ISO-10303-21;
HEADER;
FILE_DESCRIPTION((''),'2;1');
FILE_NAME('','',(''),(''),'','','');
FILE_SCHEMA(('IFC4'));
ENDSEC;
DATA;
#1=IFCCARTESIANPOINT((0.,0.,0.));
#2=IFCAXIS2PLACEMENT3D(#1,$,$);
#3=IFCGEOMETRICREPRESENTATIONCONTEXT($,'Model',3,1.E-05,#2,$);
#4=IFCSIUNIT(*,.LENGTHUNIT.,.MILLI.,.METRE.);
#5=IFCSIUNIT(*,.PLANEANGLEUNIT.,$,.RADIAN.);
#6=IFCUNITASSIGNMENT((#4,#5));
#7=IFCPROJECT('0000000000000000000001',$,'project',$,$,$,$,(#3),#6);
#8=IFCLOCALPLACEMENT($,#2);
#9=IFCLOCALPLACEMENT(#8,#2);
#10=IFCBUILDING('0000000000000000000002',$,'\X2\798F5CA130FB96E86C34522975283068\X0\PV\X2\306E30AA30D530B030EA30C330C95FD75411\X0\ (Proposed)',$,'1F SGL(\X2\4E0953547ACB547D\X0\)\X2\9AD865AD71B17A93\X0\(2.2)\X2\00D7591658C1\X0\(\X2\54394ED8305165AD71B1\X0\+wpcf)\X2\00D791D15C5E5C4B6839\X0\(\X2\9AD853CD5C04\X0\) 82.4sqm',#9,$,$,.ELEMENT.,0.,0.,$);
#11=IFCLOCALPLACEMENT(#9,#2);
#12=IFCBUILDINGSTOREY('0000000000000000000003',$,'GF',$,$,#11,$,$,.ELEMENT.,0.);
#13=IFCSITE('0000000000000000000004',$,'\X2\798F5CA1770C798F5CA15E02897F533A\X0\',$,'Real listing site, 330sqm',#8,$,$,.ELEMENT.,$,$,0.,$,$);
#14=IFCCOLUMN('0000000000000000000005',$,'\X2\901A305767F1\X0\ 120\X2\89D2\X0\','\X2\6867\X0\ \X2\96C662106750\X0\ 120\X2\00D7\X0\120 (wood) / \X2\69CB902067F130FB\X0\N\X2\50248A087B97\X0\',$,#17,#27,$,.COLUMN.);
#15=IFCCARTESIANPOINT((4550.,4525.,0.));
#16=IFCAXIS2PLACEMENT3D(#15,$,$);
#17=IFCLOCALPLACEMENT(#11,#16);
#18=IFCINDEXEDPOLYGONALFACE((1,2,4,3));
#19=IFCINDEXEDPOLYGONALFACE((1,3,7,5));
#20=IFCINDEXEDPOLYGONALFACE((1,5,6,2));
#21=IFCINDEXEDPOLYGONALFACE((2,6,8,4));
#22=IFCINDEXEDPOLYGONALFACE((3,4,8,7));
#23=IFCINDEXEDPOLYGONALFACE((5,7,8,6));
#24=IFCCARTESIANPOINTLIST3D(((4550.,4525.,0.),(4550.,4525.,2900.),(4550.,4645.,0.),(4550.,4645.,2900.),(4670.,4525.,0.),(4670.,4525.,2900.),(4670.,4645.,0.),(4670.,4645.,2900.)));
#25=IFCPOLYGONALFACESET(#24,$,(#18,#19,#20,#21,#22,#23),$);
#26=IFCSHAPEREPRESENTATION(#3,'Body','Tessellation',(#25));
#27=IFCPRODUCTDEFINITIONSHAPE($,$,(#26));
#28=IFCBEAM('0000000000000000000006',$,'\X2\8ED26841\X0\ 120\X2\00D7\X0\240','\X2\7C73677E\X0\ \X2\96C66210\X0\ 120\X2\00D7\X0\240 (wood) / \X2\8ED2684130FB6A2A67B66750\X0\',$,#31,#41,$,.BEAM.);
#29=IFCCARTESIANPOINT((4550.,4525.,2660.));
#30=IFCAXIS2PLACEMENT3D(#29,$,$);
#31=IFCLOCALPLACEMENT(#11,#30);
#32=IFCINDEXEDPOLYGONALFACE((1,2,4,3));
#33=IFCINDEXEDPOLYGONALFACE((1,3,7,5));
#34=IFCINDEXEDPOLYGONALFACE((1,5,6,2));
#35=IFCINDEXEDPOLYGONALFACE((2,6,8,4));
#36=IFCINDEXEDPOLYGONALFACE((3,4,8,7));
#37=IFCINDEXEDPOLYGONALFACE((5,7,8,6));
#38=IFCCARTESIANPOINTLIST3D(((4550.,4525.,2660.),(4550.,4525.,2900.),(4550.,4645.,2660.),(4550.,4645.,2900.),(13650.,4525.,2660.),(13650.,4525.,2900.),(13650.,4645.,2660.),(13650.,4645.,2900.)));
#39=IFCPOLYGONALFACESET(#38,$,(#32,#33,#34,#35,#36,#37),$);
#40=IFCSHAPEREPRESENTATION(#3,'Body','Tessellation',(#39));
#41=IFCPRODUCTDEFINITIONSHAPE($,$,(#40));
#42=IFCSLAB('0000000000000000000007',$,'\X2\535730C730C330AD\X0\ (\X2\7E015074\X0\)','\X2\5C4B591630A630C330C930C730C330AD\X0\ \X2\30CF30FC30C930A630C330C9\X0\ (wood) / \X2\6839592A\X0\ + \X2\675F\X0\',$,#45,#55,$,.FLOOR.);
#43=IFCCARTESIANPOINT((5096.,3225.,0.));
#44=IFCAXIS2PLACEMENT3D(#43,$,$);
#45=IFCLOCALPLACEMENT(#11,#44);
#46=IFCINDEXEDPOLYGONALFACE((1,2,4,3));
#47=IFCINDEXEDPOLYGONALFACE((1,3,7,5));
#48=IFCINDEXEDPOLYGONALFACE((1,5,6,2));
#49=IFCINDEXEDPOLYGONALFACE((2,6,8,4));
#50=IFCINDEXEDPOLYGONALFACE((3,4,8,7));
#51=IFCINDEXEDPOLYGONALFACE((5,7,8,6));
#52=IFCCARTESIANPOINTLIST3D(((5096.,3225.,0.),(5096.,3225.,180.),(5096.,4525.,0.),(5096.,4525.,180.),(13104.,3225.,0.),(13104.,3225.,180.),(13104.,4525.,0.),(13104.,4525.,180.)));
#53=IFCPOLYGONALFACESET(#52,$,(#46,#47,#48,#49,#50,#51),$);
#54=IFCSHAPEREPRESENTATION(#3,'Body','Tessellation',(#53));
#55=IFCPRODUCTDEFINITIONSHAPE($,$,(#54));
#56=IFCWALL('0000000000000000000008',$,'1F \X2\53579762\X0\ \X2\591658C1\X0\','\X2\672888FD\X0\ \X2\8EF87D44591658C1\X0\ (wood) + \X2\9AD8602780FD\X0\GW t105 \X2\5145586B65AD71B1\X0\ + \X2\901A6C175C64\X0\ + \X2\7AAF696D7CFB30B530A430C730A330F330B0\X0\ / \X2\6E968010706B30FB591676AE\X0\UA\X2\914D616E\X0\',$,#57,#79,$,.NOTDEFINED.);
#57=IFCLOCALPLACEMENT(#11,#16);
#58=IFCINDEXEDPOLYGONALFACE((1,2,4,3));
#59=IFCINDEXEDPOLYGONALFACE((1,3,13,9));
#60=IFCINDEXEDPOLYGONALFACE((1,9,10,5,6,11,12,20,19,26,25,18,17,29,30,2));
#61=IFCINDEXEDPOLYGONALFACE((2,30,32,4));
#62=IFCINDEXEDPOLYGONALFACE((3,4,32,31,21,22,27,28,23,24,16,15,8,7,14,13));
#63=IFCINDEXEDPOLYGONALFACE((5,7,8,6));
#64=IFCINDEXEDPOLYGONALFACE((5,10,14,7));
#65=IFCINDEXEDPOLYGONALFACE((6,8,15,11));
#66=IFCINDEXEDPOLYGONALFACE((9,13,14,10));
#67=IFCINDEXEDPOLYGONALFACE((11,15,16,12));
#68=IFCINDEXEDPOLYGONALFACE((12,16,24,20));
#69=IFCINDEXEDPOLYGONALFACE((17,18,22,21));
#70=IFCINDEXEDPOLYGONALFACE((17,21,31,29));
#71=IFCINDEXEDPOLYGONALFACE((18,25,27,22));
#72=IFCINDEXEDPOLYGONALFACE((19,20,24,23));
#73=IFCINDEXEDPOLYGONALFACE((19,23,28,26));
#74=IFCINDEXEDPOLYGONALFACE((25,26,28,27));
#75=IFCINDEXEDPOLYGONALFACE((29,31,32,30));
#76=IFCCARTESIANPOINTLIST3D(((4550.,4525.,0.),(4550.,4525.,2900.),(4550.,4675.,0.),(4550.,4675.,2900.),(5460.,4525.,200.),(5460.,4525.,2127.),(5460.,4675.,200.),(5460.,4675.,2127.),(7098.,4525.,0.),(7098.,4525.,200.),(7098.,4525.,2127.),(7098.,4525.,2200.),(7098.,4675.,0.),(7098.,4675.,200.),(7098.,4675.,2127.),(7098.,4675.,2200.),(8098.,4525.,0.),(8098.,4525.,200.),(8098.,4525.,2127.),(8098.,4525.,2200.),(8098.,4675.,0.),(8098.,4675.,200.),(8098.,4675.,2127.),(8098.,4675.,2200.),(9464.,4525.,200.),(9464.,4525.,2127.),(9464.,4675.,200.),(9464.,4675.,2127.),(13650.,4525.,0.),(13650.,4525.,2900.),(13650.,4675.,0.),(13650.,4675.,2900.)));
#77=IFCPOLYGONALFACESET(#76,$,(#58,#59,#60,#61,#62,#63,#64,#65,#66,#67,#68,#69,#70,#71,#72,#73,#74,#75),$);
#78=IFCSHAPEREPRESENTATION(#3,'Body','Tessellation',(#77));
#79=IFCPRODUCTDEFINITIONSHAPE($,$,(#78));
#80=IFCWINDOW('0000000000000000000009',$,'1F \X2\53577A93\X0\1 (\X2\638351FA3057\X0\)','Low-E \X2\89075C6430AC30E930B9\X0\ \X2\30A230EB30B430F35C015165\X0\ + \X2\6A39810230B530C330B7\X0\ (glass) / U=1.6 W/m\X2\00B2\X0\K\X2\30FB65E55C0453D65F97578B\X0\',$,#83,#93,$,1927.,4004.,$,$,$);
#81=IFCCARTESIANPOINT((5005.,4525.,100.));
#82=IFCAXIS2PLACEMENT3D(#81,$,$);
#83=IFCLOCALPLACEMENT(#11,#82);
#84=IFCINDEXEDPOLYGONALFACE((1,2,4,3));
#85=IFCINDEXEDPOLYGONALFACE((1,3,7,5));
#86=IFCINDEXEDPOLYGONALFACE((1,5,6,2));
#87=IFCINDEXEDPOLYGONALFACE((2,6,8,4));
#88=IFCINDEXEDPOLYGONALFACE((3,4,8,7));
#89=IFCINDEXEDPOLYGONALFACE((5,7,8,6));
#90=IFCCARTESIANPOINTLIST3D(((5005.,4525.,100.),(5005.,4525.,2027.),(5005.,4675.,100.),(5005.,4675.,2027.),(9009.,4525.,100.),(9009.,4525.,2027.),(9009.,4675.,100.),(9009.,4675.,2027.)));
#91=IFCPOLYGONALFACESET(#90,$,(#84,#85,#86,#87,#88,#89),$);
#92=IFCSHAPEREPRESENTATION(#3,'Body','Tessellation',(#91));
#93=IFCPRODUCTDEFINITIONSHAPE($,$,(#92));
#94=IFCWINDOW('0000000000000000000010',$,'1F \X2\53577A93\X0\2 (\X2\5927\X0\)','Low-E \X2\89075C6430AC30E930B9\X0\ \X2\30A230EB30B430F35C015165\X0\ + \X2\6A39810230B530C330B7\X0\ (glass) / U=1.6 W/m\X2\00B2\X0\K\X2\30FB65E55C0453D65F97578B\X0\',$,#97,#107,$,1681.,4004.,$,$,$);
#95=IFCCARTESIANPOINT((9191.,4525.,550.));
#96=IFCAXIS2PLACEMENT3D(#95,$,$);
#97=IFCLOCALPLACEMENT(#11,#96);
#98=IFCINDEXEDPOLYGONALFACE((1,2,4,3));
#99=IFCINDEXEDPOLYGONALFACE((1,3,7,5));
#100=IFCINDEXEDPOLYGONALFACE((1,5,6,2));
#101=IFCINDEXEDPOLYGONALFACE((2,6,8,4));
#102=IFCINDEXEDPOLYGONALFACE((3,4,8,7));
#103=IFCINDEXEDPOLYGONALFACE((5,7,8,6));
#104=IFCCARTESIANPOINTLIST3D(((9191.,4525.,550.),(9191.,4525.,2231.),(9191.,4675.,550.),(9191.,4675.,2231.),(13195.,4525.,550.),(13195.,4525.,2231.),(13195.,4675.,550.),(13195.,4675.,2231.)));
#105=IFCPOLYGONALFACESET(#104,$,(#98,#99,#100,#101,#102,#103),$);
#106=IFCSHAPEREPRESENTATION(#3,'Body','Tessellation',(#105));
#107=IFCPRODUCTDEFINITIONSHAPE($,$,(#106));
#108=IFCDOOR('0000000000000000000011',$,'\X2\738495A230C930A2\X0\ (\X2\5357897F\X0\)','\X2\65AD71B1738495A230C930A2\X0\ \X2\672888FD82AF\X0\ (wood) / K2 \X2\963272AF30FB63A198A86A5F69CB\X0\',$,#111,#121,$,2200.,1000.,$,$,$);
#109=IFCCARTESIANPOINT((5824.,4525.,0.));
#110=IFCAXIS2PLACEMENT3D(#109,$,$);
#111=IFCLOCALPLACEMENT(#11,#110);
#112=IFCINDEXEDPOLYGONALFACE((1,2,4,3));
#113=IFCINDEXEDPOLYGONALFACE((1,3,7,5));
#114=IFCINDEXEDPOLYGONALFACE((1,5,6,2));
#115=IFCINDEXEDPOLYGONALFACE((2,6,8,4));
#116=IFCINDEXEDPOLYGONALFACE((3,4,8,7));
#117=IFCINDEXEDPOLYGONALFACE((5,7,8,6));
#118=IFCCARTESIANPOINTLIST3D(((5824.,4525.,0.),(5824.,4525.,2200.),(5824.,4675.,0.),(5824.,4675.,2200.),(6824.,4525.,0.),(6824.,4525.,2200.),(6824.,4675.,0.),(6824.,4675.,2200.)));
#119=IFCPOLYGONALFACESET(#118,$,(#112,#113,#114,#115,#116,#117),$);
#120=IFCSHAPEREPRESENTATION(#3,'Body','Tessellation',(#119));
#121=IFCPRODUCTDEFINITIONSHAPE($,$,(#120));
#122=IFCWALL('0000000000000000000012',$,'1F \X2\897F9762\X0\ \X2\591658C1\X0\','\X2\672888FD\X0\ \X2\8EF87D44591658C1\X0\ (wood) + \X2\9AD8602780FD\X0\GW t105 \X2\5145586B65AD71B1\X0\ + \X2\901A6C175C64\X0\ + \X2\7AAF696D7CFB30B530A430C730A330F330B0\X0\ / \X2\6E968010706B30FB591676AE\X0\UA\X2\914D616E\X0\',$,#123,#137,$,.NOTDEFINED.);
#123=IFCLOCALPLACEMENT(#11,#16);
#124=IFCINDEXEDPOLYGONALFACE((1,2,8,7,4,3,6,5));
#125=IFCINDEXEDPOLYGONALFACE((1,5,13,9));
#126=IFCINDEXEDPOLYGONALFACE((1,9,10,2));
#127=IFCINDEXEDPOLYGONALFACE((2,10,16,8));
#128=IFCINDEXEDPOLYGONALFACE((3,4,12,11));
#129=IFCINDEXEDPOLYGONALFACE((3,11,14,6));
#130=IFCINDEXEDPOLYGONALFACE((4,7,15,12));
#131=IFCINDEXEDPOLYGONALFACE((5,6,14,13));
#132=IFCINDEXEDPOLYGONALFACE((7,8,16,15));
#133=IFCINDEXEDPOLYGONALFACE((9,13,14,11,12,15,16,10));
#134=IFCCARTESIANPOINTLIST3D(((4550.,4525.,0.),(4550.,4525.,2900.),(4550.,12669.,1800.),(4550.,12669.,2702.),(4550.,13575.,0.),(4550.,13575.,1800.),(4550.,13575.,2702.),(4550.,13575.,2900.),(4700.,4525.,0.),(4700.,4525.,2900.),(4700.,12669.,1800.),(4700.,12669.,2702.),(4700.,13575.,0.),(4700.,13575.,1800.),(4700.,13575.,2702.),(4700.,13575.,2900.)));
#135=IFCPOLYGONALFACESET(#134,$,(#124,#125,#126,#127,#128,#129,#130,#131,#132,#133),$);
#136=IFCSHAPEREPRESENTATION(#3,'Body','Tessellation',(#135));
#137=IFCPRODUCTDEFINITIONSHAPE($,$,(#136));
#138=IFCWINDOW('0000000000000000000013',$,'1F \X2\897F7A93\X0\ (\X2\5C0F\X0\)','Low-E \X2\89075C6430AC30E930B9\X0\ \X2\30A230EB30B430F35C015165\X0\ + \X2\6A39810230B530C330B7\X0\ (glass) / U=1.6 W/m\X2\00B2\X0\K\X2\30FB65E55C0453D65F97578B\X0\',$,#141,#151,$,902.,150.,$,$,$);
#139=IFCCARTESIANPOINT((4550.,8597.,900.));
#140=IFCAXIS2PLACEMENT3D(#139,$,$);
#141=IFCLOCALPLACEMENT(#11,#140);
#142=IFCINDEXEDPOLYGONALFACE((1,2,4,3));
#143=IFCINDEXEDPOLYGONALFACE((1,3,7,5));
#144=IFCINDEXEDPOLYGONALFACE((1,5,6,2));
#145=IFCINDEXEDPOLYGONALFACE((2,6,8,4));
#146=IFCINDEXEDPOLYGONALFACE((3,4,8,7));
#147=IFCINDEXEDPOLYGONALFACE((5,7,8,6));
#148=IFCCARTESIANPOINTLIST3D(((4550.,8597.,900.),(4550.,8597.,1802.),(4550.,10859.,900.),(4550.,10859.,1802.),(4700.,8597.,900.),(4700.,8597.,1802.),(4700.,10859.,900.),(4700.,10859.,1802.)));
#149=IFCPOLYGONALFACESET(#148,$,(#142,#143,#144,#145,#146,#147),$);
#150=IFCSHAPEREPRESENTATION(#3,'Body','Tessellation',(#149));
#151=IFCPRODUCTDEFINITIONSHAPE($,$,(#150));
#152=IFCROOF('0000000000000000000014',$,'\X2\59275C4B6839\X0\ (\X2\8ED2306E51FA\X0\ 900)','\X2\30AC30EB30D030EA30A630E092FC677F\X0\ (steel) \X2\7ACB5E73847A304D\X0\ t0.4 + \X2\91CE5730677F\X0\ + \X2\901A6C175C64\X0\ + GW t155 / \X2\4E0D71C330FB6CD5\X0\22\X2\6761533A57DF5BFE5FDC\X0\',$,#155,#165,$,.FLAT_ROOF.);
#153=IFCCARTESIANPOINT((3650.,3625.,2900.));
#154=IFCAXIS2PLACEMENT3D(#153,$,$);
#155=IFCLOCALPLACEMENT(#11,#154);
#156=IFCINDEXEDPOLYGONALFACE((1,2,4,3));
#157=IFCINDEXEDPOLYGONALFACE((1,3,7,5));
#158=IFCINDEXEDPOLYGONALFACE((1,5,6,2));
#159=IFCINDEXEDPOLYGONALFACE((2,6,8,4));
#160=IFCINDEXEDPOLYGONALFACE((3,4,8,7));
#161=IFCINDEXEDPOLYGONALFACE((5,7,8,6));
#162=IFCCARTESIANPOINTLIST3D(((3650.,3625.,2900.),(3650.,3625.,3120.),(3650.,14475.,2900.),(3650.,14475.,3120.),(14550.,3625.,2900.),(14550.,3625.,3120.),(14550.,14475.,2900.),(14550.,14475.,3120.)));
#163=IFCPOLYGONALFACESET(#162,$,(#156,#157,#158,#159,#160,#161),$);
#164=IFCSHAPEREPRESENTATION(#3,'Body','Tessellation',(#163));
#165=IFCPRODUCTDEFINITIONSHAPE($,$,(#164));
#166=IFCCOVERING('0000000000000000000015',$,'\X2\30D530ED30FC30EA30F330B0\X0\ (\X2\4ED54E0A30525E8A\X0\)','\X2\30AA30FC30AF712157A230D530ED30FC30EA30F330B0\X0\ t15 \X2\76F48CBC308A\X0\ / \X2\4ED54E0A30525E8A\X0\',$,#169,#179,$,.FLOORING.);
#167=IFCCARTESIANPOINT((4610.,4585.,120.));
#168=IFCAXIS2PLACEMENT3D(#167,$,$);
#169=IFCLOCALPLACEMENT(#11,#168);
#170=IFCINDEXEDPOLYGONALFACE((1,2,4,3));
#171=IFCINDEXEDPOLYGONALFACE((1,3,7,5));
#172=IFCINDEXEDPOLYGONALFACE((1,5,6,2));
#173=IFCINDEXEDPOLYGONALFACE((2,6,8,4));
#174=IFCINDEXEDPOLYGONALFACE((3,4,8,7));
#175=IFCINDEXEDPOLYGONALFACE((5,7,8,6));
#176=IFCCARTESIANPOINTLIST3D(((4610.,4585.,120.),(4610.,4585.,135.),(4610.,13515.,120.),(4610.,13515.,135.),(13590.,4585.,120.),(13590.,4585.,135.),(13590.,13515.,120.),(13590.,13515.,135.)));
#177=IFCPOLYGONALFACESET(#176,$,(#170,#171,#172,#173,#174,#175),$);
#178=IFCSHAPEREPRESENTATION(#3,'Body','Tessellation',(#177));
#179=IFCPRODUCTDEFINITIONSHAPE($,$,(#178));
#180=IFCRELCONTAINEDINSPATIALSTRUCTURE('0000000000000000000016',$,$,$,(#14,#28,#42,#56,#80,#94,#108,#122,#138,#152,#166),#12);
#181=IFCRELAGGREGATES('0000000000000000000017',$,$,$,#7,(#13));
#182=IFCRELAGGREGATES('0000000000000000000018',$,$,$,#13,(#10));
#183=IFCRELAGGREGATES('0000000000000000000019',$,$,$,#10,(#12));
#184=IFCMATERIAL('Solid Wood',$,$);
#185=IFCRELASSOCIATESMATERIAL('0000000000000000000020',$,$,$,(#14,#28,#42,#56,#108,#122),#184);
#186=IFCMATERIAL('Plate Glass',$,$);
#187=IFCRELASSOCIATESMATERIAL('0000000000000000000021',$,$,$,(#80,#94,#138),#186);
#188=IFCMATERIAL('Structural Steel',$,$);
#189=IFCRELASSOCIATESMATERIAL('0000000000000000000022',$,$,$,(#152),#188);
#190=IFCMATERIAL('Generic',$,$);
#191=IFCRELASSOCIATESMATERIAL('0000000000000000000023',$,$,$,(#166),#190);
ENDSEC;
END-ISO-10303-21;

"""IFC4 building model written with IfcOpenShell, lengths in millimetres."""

from ifc_helpers import new_model, si_unit, frame, frame_2d, origin, place, context, project, spatial, rectangle, extrude, material, element, fill, save


model = new_model("IFC4")

# Units and contexts
model_context = context("Model", 3, precision=1e-05, world=origin())
ifc_project = project(units=[si_unit("LENGTHUNIT", "METRE", prefix="MILLI"), si_unit("PLANEANGLEUNIT", "RADIAN")], contexts=[model_context])

# Site, building, storey
site_placement = place(None, origin())
site = spatial("IfcSite", under=ifc_project, at=site_placement, Name="福岡県福岡市西区", ObjectType="Real listing site, 330sqm", CompositionType="ELEMENT", RefElevation=0.0)
building_placement = place(site_placement, origin())
building = spatial("IfcBuilding", under=site, at=building_placement, Name="福岡・雨水利用とPVのオフグリッド志向 (Proposed)", ObjectType="1F SGL(三協立命)高断熱窓(2.2)×外壁(吹付け断熱+wpcf)×金属屋根(高反射) 82.4sqm", CompositionType="ELEMENT", ElevationOfRefHeight=0.0, ElevationOfTerrain=0.0)
storey_placement = place(building_placement, origin())
storey = spatial("IfcBuildingStorey", under=building, at=storey_placement, Name="GF", CompositionType="ELEMENT", Elevation=0.0)

# Column
ifc_material_1 = material(Name="Solid Wood")
column_placement = place(storey_placement, frame((4550.0, 4525.0, 0.0)))
element("IfcColumn", 1, at=column_placement, inside=storey, material=ifc_material_1, Name="通し柱 120角", Description="桧 集成材 120×120 (wood) / 構造柱・N値計算", PredefinedType="COLUMN", context=model_context, shape_type="SweptSolid", body=[
    extrude(rectangle(XDim=120.0, YDim=120.0, at=frame_2d((60.0, 60.0))), frame((4550.0, 4525.0, 0.0)), (0.0, 0.0, 1.0), 2900.0),
])

# Beam
beam_1_placement = place(storey_placement, frame((4550.0, 4525.0, 2660.0)))
element("IfcBeam", 2, at=beam_1_placement, inside=storey, material=ifc_material_1, Name="軒桁 120×240", Description="米松 集成 120×240 (wood) / 軒桁・横架材", PredefinedType="BEAM", context=model_context, shape_type="SweptSolid", body=[
    extrude(rectangle(XDim=9100.0, YDim=120.0, at=frame_2d((4550.0, 60.0))), frame((4550.0, 4525.0, 2660.0)), (0.0, 0.0, 1.0), 240.0),
])

# Slab
slab_1_placement = place(storey_placement, frame((5096.0, 3225.0, 0.0)))
element("IfcSlab", 3, at=slab_1_placement, inside=storey, material=ifc_material_1, Name="南デッキ (縁側)", Description="屋外ウッドデッキ ハードウッド (wood) / 根太 + 束", PredefinedType="FLOOR", context=model_context, shape_type="SweptSolid", body=[
    extrude(rectangle(XDim=8008.0, YDim=1300.0, at=frame_2d((4004.0, 650.0))), frame((5096.0, 3225.0, 0.0)), (0.0, 0.0, 1.0), 180.0),
])

# Wall, openings, windows, door
wall_1_placement = place(storey_placement, frame((4550.0, 4525.0, 0.0)))
wall_1 = element("IfcWall", 4, at=wall_1_placement, inside=storey, material=ifc_material_1, Name="1F 南面 外壁", Description="木製 軸組外壁 (wood) + 高性能GW t105 充填断熱 + 通気層 + 窯業系サイディング / 準耐火・外皮UA配慮", PredefinedType="NOTDEFINED", context=model_context, shape_type="SweptSolid", body=[
    extrude(rectangle(XDim=9100.0, YDim=150.0, at=frame_2d((4550.0, 75.0))), frame((4550.0, 4525.0, 0.0)), (0.0, 0.0, 1.0), 2900.0),
])
opening_1_placement = place(storey_placement, frame((5005.0, 4525.0, 100.0)))
opening_1 = element("IfcOpeningElement", 5, at=opening_1_placement, cuts=wall_1, PredefinedType="NOTDEFINED", context=model_context, shape_type="SweptSolid", body=[
    extrude(rectangle(XDim=4004.0, YDim=150.0, at=frame_2d((2002.0, 75.0))), frame((5005.0, 4525.0, 100.0)), (0.0, 0.0, 1.0), 1927.0),
])
opening_2_placement = place(storey_placement, frame((9191.0, 4525.0, 550.0)))
opening_2 = element("IfcOpeningElement", 6, at=opening_2_placement, cuts=wall_1, PredefinedType="NOTDEFINED", context=model_context, shape_type="SweptSolid", body=[
    extrude(rectangle(XDim=4004.0, YDim=150.0, at=frame_2d((2002.0, 75.0))), frame((9191.0, 4525.0, 550.0)), (0.0, 0.0, 1.0), 1681.0),
])
opening_3_placement = place(storey_placement, frame((5824.0, 4525.0, 0.0)))
opening_3 = element("IfcOpeningElement", 7, at=opening_3_placement, cuts=wall_1, PredefinedType="NOTDEFINED", context=model_context, shape_type="SweptSolid", body=[
    extrude(rectangle(XDim=1000.0, YDim=150.0, at=frame_2d((500.0, 75.0))), frame((5824.0, 4525.0, 0.0)), (0.0, 0.0, 1.0), 2200.0),
])
ifc_material_2 = material(Name="Plate Glass")
window_1_placement = place(storey_placement, frame((5005.0, 4525.0, 100.0)))
window_1 = element("IfcWindow", 8, at=window_1_placement, inside=storey, material=ifc_material_2, Name="1F 南窓1 (掃出し)", Description="Low-E 複層ガラス アルゴン封入 + 樹脂サッシ (glass) / U=1.6 W/m²K・日射取得型", OverallHeight=1927.0, OverallWidth=4004.0, context=model_context, shape_type="SweptSolid", body=[
    extrude(rectangle(XDim=4004.0, YDim=150.0, at=frame_2d((2002.0, 75.0))), frame((5005.0, 4525.0, 100.0)), (0.0, 0.0, 1.0), 1927.0),
])
fill(opening_1, window_1)
window_2_placement = place(storey_placement, frame((9191.0, 4525.0, 550.0)))
window_2 = element("IfcWindow", 9, at=window_2_placement, inside=storey, material=ifc_material_2, Name="1F 南窓2 (大)", Description="Low-E 複層ガラス アルゴン封入 + 樹脂サッシ (glass) / U=1.6 W/m²K・日射取得型", OverallHeight=1681.0, OverallWidth=4004.0, context=model_context, shape_type="SweptSolid", body=[
    extrude(rectangle(XDim=4004.0, YDim=150.0, at=frame_2d((2002.0, 75.0))), frame((9191.0, 4525.0, 550.0)), (0.0, 0.0, 1.0), 1681.0),
])
fill(opening_2, window_2)
door_placement = place(storey_placement, frame((5824.0, 4525.0, 0.0)))
door = element("IfcDoor", 10, at=door_placement, inside=storey, material=ifc_material_1, Name="玄関ドア (南西)", Description="断熱玄関ドア 木製芯 (wood) / K2 防犯・採風機構", OverallHeight=2200.0, OverallWidth=1000.0, context=model_context, shape_type="SweptSolid", body=[
    extrude(rectangle(XDim=1000.0, YDim=150.0, at=frame_2d((500.0, 75.0))), frame((5824.0, 4525.0, 0.0)), (0.0, 0.0, 1.0), 2200.0),
])
fill(opening_3, door)

# Wall, opening, window
wall_2_placement = place(storey_placement, frame((4550.0, 4525.0, 0.0)))
wall_2 = element("IfcWall", 11, at=wall_2_placement, inside=storey, material=ifc_material_1, Name="1F 西面 外壁", Description="木製 軸組外壁 (wood) + 高性能GW t105 充填断熱 + 通気層 + 窯業系サイディング / 準耐火・外皮UA配慮", PredefinedType="NOTDEFINED", context=model_context, shape_type="SweptSolid", body=[
    extrude(rectangle(XDim=150.0, YDim=9050.0, at=frame_2d((75.0, 4525.0))), frame((4550.0, 4525.0, 0.0)), (0.0, 0.0, 1.0), 2900.0),
])
opening_4_placement = place(storey_placement, frame((4550.0, 8597.0, 900.0)))
opening_4 = element("IfcOpeningElement", 12, at=opening_4_placement, cuts=wall_2, PredefinedType="NOTDEFINED", context=model_context, shape_type="SweptSolid", body=[
    extrude(rectangle(XDim=150.0, YDim=2262.0, at=frame_2d((75.0, 1131.0))), frame((4550.0, 8597.0, 900.0)), (0.0, 0.0, 1.0), 902.0),
])
window_3_placement = place(storey_placement, frame((4550.0, 8597.0, 900.0)))
window_3 = element("IfcWindow", 13, at=window_3_placement, inside=storey, material=ifc_material_2, Name="1F 西窓 (小)", Description="Low-E 複層ガラス アルゴン封入 + 樹脂サッシ (glass) / U=1.6 W/m²K・日射取得型", OverallHeight=902.0, OverallWidth=150.0, context=model_context, shape_type="SweptSolid", body=[
    extrude(rectangle(XDim=150.0, YDim=2262.0, at=frame_2d((75.0, 1131.0))), frame((4550.0, 8597.0, 900.0)), (0.0, 0.0, 1.0), 902.0),
])
fill(opening_4, window_3)

# Roof
ifc_material_3 = material(Name="Structural Steel")
roof_placement = place(storey_placement, frame((3650.0, 3625.0, 2900.0)))
element("IfcRoof", 14, at=roof_placement, inside=storey, material=ifc_material_3, Name="大屋根 (軒の出 900)", Description="ガルバリウム鋼板 (steel) 立平葺き t0.4 + 野地板 + 通気層 + GW t155 / 不燃・法22条区域対応", PredefinedType="FLAT_ROOF", context=model_context, shape_type="SweptSolid", body=[
    extrude(rectangle(XDim=10900.0, YDim=10850.0, at=frame_2d((5450.0, 5425.0))), frame((3650.0, 3625.0, 2900.0)), (0.0, 0.0, 1.0), 220.0),
])

# Covering
ifc_material_4 = material(Name="Generic")
covering_1_placement = place(storey_placement, frame((4610.0, 4585.0, 120.0)))
element("IfcCovering", 15, at=covering_1_placement, inside=storey, material=ifc_material_4, Name="フローリング (仕上げ床)", Description="オーク無垢フローリング t15 直貼り / 仕上げ床", PredefinedType="FLOORING", context=model_context, shape_type="SweptSolid", body=[
    extrude(rectangle(XDim=8980.0, YDim=8930.0, at=frame_2d((4490.0, 4465.0))), frame((4610.0, 4585.0, 120.0)), (0.0, 0.0, 1.0), 15.0),
])

save(model, "model.ifc")
